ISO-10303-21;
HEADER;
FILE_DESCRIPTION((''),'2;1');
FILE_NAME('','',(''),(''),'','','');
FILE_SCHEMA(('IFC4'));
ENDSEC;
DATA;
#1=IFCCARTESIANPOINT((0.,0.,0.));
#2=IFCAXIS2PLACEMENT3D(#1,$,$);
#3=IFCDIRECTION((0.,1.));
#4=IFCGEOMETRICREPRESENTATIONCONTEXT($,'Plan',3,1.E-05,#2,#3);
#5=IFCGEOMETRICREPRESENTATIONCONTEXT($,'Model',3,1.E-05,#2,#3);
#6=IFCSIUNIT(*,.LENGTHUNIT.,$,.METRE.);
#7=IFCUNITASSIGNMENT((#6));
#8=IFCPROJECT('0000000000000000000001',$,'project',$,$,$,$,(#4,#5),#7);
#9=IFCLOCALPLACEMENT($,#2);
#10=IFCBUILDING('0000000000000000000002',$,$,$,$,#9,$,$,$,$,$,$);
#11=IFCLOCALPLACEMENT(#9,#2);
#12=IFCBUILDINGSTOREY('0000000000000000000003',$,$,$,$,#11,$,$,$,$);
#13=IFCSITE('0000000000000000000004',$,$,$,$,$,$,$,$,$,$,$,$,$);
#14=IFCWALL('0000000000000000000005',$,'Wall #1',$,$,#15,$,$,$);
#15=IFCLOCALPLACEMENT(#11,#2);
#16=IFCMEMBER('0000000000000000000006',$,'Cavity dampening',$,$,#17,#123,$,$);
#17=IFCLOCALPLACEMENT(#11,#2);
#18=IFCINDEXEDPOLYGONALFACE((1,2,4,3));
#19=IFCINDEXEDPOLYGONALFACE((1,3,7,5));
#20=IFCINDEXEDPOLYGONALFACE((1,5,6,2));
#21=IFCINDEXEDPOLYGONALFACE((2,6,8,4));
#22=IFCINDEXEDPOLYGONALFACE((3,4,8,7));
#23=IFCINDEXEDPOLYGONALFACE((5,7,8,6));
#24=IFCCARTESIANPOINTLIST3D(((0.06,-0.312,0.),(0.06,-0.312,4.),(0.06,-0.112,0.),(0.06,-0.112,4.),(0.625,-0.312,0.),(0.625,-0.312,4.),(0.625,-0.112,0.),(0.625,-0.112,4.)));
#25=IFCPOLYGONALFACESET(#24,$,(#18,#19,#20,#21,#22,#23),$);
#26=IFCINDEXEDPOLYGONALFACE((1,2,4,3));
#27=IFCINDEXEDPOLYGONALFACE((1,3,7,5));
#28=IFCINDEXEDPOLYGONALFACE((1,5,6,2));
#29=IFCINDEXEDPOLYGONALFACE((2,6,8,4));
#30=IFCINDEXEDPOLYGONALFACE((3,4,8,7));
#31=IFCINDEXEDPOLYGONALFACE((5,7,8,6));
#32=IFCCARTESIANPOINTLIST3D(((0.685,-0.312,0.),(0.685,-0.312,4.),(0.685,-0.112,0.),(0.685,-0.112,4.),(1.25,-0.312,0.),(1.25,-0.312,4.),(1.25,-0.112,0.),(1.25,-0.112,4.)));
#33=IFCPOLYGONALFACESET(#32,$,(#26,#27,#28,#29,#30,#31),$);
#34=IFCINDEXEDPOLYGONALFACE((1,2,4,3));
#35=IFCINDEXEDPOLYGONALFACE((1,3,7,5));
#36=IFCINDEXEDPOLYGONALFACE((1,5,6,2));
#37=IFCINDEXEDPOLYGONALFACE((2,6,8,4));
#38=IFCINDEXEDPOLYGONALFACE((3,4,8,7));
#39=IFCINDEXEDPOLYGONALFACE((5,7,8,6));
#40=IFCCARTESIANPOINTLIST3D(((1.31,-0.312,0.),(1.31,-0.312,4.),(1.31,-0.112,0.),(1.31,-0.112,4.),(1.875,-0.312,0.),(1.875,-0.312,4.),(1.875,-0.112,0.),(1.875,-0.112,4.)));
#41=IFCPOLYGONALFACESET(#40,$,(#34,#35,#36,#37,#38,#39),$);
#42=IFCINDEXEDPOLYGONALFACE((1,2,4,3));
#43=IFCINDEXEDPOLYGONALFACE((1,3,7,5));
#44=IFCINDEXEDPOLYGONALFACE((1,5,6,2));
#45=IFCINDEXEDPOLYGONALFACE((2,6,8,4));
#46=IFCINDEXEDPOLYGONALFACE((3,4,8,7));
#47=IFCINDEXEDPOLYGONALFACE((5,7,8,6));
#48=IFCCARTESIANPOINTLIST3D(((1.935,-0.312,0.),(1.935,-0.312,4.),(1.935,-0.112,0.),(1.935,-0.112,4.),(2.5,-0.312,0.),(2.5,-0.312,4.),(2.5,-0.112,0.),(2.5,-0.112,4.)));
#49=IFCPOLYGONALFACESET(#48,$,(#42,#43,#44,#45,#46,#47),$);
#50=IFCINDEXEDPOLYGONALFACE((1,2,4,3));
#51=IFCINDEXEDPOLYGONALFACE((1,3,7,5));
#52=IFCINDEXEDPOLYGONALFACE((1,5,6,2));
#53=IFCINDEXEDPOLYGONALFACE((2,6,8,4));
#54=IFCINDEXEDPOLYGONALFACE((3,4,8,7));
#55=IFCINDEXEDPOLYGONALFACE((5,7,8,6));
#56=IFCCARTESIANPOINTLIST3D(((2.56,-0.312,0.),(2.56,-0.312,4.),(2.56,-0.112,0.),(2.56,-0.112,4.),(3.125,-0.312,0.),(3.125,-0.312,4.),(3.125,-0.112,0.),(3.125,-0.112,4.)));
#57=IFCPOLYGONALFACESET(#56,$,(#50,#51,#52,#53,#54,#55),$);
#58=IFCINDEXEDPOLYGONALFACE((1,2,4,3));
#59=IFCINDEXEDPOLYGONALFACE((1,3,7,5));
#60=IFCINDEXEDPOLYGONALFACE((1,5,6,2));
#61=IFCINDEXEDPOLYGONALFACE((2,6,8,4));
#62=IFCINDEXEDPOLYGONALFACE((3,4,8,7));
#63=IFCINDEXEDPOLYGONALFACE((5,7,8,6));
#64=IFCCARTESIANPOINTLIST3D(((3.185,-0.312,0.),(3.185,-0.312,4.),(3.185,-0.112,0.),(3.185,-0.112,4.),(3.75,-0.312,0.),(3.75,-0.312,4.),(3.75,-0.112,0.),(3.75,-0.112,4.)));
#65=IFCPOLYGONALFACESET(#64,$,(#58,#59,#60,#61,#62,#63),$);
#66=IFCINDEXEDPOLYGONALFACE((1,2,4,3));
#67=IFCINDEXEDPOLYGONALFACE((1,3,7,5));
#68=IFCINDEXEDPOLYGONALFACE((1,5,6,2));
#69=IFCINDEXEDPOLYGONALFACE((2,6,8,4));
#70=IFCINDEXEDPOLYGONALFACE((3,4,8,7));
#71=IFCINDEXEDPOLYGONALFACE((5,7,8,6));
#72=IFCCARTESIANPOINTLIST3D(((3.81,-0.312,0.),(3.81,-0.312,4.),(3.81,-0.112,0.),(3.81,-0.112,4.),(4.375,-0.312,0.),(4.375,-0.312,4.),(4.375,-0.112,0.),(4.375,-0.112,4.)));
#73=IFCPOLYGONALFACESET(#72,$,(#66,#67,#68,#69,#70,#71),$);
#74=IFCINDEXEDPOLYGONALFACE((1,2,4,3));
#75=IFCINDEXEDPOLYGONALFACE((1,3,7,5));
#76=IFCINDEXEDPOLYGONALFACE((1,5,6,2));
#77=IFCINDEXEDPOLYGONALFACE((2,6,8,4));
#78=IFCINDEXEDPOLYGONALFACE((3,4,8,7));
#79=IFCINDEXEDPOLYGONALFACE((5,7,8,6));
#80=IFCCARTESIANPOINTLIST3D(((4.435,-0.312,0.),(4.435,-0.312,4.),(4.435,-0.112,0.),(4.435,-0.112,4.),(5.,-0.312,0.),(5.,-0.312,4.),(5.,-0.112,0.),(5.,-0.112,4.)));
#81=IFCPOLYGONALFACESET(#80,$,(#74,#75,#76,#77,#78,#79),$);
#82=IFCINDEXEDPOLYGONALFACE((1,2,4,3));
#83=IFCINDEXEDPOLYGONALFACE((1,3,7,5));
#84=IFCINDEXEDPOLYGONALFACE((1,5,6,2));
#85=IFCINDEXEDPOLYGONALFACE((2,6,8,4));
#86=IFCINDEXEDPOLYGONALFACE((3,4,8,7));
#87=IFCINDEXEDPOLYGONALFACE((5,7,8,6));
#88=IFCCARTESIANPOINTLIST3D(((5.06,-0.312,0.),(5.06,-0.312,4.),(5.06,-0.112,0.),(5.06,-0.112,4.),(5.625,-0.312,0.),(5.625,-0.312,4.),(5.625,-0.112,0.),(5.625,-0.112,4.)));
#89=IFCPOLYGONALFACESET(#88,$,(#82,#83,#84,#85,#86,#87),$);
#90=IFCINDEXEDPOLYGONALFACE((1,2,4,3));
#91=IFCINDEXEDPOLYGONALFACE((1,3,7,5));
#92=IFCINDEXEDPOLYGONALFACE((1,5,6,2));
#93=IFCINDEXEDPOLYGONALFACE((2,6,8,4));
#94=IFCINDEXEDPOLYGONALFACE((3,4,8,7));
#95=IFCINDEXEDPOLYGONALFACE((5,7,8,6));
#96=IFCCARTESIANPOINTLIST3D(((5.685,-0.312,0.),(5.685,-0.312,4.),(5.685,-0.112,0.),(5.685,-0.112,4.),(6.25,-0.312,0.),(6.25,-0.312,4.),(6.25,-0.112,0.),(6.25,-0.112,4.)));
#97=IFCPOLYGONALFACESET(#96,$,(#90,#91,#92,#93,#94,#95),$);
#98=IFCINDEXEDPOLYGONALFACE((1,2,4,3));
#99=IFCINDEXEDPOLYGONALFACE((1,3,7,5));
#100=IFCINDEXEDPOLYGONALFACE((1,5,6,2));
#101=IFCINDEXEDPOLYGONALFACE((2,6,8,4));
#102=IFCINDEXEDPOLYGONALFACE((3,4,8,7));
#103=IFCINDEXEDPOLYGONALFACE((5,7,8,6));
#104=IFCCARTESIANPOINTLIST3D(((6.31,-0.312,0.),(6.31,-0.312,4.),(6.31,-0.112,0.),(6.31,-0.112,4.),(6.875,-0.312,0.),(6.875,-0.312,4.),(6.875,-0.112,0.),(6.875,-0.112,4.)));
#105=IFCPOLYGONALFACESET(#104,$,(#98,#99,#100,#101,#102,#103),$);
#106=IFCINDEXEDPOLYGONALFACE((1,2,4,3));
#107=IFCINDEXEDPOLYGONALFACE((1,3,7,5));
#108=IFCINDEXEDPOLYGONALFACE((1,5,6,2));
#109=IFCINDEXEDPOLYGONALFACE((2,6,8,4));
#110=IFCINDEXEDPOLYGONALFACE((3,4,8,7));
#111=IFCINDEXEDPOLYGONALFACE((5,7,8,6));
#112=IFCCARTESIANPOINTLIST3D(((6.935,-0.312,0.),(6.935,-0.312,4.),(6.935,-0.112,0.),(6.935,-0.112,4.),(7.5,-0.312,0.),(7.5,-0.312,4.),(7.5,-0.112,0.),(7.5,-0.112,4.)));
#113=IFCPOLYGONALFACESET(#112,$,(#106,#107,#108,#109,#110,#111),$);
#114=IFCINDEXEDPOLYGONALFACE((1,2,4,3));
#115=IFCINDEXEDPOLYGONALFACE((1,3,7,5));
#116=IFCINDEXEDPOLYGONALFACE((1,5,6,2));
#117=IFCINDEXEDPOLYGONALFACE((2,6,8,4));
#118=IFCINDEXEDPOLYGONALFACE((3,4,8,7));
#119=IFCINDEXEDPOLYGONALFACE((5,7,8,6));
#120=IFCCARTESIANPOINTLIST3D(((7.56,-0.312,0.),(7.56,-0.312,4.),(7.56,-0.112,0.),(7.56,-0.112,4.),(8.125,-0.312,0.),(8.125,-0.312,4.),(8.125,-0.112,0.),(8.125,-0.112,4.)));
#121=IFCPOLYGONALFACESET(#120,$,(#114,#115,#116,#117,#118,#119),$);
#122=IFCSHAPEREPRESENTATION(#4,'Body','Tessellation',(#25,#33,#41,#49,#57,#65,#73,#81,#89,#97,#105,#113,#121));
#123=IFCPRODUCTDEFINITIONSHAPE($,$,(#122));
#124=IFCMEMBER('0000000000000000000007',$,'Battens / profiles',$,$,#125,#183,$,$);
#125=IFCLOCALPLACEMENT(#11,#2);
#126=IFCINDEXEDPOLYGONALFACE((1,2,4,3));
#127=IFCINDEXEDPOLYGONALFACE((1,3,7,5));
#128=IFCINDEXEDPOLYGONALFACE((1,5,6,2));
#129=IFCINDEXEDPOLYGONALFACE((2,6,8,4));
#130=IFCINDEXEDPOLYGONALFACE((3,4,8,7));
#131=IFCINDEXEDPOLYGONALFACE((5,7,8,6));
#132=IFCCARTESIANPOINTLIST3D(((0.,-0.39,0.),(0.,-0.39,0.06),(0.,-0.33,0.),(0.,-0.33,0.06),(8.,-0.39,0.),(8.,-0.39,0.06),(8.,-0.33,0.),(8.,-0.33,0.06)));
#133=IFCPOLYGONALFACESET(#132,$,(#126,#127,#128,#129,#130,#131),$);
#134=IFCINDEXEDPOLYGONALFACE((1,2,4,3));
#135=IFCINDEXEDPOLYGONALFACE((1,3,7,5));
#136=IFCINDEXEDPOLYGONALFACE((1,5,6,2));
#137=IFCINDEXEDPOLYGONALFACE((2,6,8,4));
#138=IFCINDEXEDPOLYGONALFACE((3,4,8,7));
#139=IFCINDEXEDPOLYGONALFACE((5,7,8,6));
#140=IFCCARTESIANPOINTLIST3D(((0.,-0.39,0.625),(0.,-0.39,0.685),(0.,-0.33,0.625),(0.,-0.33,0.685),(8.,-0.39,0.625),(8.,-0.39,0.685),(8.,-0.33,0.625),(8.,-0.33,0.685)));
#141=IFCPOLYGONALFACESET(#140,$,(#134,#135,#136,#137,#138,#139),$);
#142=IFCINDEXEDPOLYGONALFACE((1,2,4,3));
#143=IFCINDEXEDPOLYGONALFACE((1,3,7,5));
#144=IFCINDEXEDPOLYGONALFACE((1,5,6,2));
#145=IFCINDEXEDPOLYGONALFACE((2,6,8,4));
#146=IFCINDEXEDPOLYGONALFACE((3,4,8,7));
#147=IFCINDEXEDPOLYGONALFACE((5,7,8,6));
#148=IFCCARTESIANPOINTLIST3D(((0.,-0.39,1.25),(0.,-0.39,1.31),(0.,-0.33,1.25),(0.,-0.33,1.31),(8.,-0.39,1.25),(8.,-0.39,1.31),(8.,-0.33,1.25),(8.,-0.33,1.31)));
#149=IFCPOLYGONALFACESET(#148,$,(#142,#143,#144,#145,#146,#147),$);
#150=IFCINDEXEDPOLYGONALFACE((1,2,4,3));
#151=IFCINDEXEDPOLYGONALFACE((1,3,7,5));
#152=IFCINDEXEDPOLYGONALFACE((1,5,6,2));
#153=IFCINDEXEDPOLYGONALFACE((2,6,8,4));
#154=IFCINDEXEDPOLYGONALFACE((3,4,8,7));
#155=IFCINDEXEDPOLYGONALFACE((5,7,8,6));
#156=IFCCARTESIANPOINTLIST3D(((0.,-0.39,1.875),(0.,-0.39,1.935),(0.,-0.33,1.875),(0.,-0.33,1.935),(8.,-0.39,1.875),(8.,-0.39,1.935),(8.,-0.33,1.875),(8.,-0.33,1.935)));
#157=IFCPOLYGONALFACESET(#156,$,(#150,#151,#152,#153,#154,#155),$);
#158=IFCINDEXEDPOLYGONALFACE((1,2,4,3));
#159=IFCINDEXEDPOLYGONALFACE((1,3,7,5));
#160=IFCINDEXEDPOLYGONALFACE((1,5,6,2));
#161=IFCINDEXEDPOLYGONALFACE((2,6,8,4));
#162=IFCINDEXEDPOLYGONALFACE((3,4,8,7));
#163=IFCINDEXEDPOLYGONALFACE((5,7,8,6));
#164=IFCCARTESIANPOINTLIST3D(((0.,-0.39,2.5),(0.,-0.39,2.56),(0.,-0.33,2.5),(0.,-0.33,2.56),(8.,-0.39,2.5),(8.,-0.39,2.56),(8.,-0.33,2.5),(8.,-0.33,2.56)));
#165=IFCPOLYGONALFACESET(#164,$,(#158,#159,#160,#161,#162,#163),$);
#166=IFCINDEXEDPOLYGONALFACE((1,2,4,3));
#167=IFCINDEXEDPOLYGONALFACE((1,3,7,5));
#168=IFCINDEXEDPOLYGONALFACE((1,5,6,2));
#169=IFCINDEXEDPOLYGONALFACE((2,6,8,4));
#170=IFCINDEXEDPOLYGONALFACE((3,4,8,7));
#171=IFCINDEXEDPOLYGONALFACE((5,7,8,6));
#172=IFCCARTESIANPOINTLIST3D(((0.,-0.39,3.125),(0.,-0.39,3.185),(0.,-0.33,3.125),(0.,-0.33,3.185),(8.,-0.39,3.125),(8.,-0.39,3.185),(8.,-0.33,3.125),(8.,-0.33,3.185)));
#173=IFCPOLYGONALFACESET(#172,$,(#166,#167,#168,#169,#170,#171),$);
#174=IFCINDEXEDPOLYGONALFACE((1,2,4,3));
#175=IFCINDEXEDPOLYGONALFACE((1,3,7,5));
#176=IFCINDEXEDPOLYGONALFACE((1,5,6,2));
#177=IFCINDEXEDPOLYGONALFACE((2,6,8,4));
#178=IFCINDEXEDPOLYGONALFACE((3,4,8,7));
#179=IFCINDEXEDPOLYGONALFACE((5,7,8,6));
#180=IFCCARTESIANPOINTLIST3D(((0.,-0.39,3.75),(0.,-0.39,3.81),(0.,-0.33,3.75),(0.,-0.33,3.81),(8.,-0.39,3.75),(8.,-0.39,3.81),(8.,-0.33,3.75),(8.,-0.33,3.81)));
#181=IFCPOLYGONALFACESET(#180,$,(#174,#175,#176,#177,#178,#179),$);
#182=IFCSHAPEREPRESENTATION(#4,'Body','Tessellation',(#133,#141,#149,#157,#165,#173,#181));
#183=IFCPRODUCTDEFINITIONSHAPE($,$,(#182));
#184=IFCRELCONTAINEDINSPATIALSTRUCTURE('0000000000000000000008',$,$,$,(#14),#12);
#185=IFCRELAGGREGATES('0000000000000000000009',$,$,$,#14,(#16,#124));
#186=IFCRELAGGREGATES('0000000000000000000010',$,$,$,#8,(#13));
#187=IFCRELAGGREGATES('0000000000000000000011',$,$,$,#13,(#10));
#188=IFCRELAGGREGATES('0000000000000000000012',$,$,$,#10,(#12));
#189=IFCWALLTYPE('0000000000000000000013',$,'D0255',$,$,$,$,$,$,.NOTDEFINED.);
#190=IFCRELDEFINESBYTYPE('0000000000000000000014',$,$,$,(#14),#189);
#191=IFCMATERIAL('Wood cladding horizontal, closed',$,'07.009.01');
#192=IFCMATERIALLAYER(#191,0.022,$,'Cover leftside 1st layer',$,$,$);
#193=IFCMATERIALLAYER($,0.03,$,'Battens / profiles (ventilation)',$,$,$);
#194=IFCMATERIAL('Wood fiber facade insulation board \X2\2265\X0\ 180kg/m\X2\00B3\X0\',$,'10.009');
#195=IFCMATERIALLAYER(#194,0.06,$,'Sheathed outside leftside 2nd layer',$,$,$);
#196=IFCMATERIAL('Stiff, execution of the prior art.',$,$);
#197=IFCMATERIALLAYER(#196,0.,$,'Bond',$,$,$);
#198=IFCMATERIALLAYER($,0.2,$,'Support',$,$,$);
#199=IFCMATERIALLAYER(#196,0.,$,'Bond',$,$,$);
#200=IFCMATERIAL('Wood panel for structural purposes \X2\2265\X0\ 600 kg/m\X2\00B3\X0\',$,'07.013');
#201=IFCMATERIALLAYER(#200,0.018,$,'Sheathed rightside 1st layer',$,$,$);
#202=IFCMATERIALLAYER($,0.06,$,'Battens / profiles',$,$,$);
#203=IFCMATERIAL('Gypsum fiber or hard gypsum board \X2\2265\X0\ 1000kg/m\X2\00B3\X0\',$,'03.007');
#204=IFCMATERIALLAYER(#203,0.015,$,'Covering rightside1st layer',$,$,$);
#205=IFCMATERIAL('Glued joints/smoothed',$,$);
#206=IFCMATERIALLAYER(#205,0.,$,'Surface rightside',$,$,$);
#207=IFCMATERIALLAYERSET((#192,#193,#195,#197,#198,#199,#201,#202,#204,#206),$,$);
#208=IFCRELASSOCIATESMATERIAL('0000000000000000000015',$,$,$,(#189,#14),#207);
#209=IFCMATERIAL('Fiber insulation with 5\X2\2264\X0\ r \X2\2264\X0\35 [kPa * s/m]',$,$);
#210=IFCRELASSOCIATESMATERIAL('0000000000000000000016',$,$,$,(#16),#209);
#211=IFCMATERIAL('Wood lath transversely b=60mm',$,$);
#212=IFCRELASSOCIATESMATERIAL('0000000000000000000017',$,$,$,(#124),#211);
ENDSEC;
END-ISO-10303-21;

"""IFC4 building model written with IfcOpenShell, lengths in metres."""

from ifc_helpers import new_model, si_unit, direction, frame, frame_2d, origin, place, context, project, spatial, rectangle, extrude, material, layer, layer_set, type_object, element, aggregate, save


model = new_model("IFC4")

# Units and contexts
plan_context = context("Plan", 3, precision=1e-05, world=origin(), true_north=direction((0.0, 1.0)))
model_context = context("Model", 3, precision=1e-05, world=origin(), true_north=direction((0.0, 1.0)))
ifc_project = project(units=[si_unit("LENGTHUNIT", "METRE")], contexts=[plan_context, model_context])

# Site, building, storey
site = spatial("IfcSite", under=ifc_project)
building_placement = place(None, origin())
building = spatial("IfcBuilding", under=site, at=building_placement)
storey_placement = place(building_placement, origin())
storey = spatial("IfcBuildingStorey", under=building, at=storey_placement)

# Wall, members
ifc_material_1 = material(Name="Wood cladding horizontal, closed", Category="07.009.01")
ifc_layer_1 = layer(ifc_material_1, 0.022, Name="Cover leftside 1st layer")
ifc_layer_2 = layer(None, 0.03, Name="Battens / profiles (ventilation)")
ifc_material_2 = material(Name="Wood fiber facade insulation board ≥ 180kg/m³", Category="10.009")
ifc_layer_3 = layer(ifc_material_2, 0.06, Name="Sheathed outside leftside 2nd layer")
ifc_material_3 = material(Name="Stiff, execution of the prior art.")
ifc_layer_4 = layer(ifc_material_3, 0.0, Name="Bond")
ifc_layer_5 = layer(None, 0.2, Name="Support")
ifc_layer_6 = layer(ifc_material_3, 0.0, Name="Bond")
ifc_material_4 = material(Name="Wood panel for structural purposes ≥ 600 kg/m³", Category="07.013")
ifc_layer_7 = layer(ifc_material_4, 0.018, Name="Sheathed rightside 1st layer")
ifc_layer_8 = layer(None, 0.06, Name="Battens / profiles")
ifc_material_5 = material(Name="Gypsum fiber or hard gypsum board ≥ 1000kg/m³", Category="03.007")
ifc_layer_9 = layer(ifc_material_5, 0.015, Name="Covering rightside1st layer")
ifc_material_6 = material(Name="Glued joints/smoothed")
ifc_layer_10 = layer(ifc_material_6, 0.0, Name="Surface rightside")
ifc_layer_set = layer_set([ifc_layer_1, ifc_layer_2, ifc_layer_3, ifc_layer_4, ifc_layer_5, ifc_layer_6, ifc_layer_7, ifc_layer_8, ifc_layer_9, ifc_layer_10])
wall_type = type_object("IfcWallType", Name="D0255", PredefinedType="NOTDEFINED", material=ifc_layer_set)
wall_placement = place(None, frame((0.0, 0.0, 0.0), z_axis=(0.0, -1.0, 0.0), x_axis=(1.0, 0.0, 0.0)))
wall = element("IfcWall", 1, at=wall_placement, inside=storey, type_object=wall_type, material=ifc_layer_set, Name="Wall #1")
ifc_material_7 = material(Name="Fiber insulation with 5≤ r ≤35 [kPa * s/m]")
member_1_placement = place(wall_placement, origin())
member_1 = element("IfcMember", 2, at=member_1_placement, material=ifc_material_7, Name="Cavity dampening", context=plan_context, shape_type="SweptSolid", body=[
    extrude(rectangle(XDim=0.565, YDim=0.2, at=frame_2d((0.2825, 0.1), x_axis=(1.0, 0.0))), frame((0.06, 4.0, 0.112), z_axis=(0.0, -1.0, 0.0), x_axis=(1.0, 0.0, 0.0)), (0.0, 0.0, 1.0), 4.0),
    extrude(rectangle(XDim=0.565, YDim=0.2, at=frame_2d((0.2825, 0.1), x_axis=(1.0, 0.0))), frame((0.685, 4.0, 0.112), z_axis=(0.0, -1.0, 0.0), x_axis=(1.0, 0.0, 0.0)), (0.0, 0.0, 1.0), 4.0),
    extrude(rectangle(XDim=0.565, YDim=0.2, at=frame_2d((0.2825, 0.1), x_axis=(1.0, 0.0))), frame((1.31, 4.0, 0.112), z_axis=(0.0, -1.0, 0.0), x_axis=(1.0, 0.0, 0.0)), (0.0, 0.0, 1.0), 4.0),
    extrude(rectangle(XDim=0.565, YDim=0.2, at=frame_2d((0.2825, 0.1), x_axis=(1.0, 0.0))), frame((1.935, 4.0, 0.112), z_axis=(0.0, -1.0, 0.0), x_axis=(1.0, 0.0, 0.0)), (0.0, 0.0, 1.0), 4.0),
    extrude(rectangle(XDim=0.565, YDim=0.2, at=frame_2d((0.2825, 0.1), x_axis=(1.0, 0.0))), frame((2.56, 4.0, 0.112), z_axis=(0.0, -1.0, 0.0), x_axis=(1.0, 0.0, 0.0)), (0.0, 0.0, 1.0), 4.0),
    extrude(rectangle(XDim=0.565, YDim=0.2, at=frame_2d((0.2825, 0.1), x_axis=(1.0, 0.0))), frame((3.185, 4.0, 0.112), z_axis=(0.0, -1.0, 0.0), x_axis=(1.0, 0.0, 0.0)), (0.0, 0.0, 1.0), 4.0),
    extrude(rectangle(XDim=0.565, YDim=0.2, at=frame_2d((0.2825, 0.1), x_axis=(1.0, 0.0))), frame((3.81, 4.0, 0.112), z_axis=(0.0, -1.0, 0.0), x_axis=(1.0, 0.0, 0.0)), (0.0, 0.0, 1.0), 4.0),
    extrude(rectangle(XDim=0.565, YDim=0.2, at=frame_2d((0.2825, 0.1), x_axis=(1.0, 0.0))), frame((4.435, 4.0, 0.112), z_axis=(0.0, -1.0, 0.0), x_axis=(1.0, 0.0, 0.0)), (0.0, 0.0, 1.0), 4.0),
    extrude(rectangle(XDim=0.565, YDim=0.2, at=frame_2d((0.2825, 0.1), x_axis=(1.0, 0.0))), frame((5.06, 4.0, 0.112), z_axis=(0.0, -1.0, 0.0), x_axis=(1.0, 0.0, 0.0)), (0.0, 0.0, 1.0), 4.0),
    extrude(rectangle(XDim=0.565, YDim=0.2, at=frame_2d((0.2825, 0.1), x_axis=(1.0, 0.0))), frame((5.685, 4.0, 0.112), z_axis=(0.0, -1.0, 0.0), x_axis=(1.0, 0.0, 0.0)), (0.0, 0.0, 1.0), 4.0),
    extrude(rectangle(XDim=0.565, YDim=0.2, at=frame_2d((0.2825, 0.1), x_axis=(1.0, 0.0))), frame((6.31, 4.0, 0.112), z_axis=(0.0, -1.0, 0.0), x_axis=(1.0, 0.0, 0.0)), (0.0, 0.0, 1.0), 4.0),
    extrude(rectangle(XDim=0.565, YDim=0.2, at=frame_2d((0.2825, 0.1), x_axis=(1.0, 0.0))), frame((6.935, 4.0, 0.112), z_axis=(0.0, -1.0, 0.0), x_axis=(1.0, 0.0, 0.0)), (0.0, 0.0, 1.0), 4.0),
    extrude(rectangle(XDim=0.565, YDim=0.2, at=frame_2d((0.2825, 0.1), x_axis=(1.0, 0.0))), frame((7.56, 4.0, 0.112), z_axis=(0.0, -1.0, 0.0), x_axis=(1.0, 0.0, 0.0)), (0.0, 0.0, 1.0), 4.0),
])
ifc_material_8 = material(Name="Wood lath transversely b=60mm")
member_2_placement = place(wall_placement, origin())
member_2 = element("IfcMember", 3, at=member_2_placement, material=ifc_material_8, Name="Battens / profiles", context=plan_context, shape_type="SweptSolid", body=[
    extrude(rectangle(XDim=0.06, YDim=0.06, at=frame_2d((0.03, 0.03), x_axis=(1.0, 0.0))), frame((0.0, 0.0, 0.33), z_axis=(1.0, 0.0, 0.0), x_axis=(0.0, 1.0, 0.0)), (0.0, 0.0, 1.0), 8.0),
    extrude(rectangle(XDim=0.06, YDim=0.06, at=frame_2d((0.03, 0.03), x_axis=(1.0, 0.0))), frame((0.0, 0.625, 0.33), z_axis=(1.0, 0.0, 0.0), x_axis=(0.0, 1.0, 0.0)), (0.0, 0.0, 1.0), 8.0),
    extrude(rectangle(XDim=0.06, YDim=0.06, at=frame_2d((0.03, 0.03), x_axis=(1.0, 0.0))), frame((0.0, 1.25, 0.33), z_axis=(1.0, 0.0, 0.0), x_axis=(0.0, 1.0, 0.0)), (0.0, 0.0, 1.0), 8.0),
    extrude(rectangle(XDim=0.06, YDim=0.06, at=frame_2d((0.03, 0.03), x_axis=(1.0, 0.0))), frame((0.0, 1.875, 0.33), z_axis=(1.0, 0.0, 0.0), x_axis=(0.0, 1.0, 0.0)), (0.0, 0.0, 1.0), 8.0),
    extrude(rectangle(XDim=0.06, YDim=0.06, at=frame_2d((0.03, 0.03), x_axis=(1.0, 0.0))), frame((0.0, 2.5, 0.33), z_axis=(1.0, 0.0, 0.0), x_axis=(0.0, 1.0, 0.0)), (0.0, 0.0, 1.0), 8.0),
    extrude(rectangle(XDim=0.06, YDim=0.06, at=frame_2d((0.03, 0.03), x_axis=(1.0, 0.0))), frame((0.0, 3.125, 0.33), z_axis=(1.0, 0.0, 0.0), x_axis=(0.0, 1.0, 0.0)), (0.0, 0.0, 1.0), 8.0),
    extrude(rectangle(XDim=0.06, YDim=0.06, at=frame_2d((0.03, 0.03), x_axis=(1.0, 0.0))), frame((0.0, 3.75, 0.33), z_axis=(1.0, 0.0, 0.0), x_axis=(0.0, 1.0, 0.0)), (0.0, 0.0, 1.0), 8.0),
])
aggregate(wall, [member_1, member_2])

save(model, "model.ifc")
